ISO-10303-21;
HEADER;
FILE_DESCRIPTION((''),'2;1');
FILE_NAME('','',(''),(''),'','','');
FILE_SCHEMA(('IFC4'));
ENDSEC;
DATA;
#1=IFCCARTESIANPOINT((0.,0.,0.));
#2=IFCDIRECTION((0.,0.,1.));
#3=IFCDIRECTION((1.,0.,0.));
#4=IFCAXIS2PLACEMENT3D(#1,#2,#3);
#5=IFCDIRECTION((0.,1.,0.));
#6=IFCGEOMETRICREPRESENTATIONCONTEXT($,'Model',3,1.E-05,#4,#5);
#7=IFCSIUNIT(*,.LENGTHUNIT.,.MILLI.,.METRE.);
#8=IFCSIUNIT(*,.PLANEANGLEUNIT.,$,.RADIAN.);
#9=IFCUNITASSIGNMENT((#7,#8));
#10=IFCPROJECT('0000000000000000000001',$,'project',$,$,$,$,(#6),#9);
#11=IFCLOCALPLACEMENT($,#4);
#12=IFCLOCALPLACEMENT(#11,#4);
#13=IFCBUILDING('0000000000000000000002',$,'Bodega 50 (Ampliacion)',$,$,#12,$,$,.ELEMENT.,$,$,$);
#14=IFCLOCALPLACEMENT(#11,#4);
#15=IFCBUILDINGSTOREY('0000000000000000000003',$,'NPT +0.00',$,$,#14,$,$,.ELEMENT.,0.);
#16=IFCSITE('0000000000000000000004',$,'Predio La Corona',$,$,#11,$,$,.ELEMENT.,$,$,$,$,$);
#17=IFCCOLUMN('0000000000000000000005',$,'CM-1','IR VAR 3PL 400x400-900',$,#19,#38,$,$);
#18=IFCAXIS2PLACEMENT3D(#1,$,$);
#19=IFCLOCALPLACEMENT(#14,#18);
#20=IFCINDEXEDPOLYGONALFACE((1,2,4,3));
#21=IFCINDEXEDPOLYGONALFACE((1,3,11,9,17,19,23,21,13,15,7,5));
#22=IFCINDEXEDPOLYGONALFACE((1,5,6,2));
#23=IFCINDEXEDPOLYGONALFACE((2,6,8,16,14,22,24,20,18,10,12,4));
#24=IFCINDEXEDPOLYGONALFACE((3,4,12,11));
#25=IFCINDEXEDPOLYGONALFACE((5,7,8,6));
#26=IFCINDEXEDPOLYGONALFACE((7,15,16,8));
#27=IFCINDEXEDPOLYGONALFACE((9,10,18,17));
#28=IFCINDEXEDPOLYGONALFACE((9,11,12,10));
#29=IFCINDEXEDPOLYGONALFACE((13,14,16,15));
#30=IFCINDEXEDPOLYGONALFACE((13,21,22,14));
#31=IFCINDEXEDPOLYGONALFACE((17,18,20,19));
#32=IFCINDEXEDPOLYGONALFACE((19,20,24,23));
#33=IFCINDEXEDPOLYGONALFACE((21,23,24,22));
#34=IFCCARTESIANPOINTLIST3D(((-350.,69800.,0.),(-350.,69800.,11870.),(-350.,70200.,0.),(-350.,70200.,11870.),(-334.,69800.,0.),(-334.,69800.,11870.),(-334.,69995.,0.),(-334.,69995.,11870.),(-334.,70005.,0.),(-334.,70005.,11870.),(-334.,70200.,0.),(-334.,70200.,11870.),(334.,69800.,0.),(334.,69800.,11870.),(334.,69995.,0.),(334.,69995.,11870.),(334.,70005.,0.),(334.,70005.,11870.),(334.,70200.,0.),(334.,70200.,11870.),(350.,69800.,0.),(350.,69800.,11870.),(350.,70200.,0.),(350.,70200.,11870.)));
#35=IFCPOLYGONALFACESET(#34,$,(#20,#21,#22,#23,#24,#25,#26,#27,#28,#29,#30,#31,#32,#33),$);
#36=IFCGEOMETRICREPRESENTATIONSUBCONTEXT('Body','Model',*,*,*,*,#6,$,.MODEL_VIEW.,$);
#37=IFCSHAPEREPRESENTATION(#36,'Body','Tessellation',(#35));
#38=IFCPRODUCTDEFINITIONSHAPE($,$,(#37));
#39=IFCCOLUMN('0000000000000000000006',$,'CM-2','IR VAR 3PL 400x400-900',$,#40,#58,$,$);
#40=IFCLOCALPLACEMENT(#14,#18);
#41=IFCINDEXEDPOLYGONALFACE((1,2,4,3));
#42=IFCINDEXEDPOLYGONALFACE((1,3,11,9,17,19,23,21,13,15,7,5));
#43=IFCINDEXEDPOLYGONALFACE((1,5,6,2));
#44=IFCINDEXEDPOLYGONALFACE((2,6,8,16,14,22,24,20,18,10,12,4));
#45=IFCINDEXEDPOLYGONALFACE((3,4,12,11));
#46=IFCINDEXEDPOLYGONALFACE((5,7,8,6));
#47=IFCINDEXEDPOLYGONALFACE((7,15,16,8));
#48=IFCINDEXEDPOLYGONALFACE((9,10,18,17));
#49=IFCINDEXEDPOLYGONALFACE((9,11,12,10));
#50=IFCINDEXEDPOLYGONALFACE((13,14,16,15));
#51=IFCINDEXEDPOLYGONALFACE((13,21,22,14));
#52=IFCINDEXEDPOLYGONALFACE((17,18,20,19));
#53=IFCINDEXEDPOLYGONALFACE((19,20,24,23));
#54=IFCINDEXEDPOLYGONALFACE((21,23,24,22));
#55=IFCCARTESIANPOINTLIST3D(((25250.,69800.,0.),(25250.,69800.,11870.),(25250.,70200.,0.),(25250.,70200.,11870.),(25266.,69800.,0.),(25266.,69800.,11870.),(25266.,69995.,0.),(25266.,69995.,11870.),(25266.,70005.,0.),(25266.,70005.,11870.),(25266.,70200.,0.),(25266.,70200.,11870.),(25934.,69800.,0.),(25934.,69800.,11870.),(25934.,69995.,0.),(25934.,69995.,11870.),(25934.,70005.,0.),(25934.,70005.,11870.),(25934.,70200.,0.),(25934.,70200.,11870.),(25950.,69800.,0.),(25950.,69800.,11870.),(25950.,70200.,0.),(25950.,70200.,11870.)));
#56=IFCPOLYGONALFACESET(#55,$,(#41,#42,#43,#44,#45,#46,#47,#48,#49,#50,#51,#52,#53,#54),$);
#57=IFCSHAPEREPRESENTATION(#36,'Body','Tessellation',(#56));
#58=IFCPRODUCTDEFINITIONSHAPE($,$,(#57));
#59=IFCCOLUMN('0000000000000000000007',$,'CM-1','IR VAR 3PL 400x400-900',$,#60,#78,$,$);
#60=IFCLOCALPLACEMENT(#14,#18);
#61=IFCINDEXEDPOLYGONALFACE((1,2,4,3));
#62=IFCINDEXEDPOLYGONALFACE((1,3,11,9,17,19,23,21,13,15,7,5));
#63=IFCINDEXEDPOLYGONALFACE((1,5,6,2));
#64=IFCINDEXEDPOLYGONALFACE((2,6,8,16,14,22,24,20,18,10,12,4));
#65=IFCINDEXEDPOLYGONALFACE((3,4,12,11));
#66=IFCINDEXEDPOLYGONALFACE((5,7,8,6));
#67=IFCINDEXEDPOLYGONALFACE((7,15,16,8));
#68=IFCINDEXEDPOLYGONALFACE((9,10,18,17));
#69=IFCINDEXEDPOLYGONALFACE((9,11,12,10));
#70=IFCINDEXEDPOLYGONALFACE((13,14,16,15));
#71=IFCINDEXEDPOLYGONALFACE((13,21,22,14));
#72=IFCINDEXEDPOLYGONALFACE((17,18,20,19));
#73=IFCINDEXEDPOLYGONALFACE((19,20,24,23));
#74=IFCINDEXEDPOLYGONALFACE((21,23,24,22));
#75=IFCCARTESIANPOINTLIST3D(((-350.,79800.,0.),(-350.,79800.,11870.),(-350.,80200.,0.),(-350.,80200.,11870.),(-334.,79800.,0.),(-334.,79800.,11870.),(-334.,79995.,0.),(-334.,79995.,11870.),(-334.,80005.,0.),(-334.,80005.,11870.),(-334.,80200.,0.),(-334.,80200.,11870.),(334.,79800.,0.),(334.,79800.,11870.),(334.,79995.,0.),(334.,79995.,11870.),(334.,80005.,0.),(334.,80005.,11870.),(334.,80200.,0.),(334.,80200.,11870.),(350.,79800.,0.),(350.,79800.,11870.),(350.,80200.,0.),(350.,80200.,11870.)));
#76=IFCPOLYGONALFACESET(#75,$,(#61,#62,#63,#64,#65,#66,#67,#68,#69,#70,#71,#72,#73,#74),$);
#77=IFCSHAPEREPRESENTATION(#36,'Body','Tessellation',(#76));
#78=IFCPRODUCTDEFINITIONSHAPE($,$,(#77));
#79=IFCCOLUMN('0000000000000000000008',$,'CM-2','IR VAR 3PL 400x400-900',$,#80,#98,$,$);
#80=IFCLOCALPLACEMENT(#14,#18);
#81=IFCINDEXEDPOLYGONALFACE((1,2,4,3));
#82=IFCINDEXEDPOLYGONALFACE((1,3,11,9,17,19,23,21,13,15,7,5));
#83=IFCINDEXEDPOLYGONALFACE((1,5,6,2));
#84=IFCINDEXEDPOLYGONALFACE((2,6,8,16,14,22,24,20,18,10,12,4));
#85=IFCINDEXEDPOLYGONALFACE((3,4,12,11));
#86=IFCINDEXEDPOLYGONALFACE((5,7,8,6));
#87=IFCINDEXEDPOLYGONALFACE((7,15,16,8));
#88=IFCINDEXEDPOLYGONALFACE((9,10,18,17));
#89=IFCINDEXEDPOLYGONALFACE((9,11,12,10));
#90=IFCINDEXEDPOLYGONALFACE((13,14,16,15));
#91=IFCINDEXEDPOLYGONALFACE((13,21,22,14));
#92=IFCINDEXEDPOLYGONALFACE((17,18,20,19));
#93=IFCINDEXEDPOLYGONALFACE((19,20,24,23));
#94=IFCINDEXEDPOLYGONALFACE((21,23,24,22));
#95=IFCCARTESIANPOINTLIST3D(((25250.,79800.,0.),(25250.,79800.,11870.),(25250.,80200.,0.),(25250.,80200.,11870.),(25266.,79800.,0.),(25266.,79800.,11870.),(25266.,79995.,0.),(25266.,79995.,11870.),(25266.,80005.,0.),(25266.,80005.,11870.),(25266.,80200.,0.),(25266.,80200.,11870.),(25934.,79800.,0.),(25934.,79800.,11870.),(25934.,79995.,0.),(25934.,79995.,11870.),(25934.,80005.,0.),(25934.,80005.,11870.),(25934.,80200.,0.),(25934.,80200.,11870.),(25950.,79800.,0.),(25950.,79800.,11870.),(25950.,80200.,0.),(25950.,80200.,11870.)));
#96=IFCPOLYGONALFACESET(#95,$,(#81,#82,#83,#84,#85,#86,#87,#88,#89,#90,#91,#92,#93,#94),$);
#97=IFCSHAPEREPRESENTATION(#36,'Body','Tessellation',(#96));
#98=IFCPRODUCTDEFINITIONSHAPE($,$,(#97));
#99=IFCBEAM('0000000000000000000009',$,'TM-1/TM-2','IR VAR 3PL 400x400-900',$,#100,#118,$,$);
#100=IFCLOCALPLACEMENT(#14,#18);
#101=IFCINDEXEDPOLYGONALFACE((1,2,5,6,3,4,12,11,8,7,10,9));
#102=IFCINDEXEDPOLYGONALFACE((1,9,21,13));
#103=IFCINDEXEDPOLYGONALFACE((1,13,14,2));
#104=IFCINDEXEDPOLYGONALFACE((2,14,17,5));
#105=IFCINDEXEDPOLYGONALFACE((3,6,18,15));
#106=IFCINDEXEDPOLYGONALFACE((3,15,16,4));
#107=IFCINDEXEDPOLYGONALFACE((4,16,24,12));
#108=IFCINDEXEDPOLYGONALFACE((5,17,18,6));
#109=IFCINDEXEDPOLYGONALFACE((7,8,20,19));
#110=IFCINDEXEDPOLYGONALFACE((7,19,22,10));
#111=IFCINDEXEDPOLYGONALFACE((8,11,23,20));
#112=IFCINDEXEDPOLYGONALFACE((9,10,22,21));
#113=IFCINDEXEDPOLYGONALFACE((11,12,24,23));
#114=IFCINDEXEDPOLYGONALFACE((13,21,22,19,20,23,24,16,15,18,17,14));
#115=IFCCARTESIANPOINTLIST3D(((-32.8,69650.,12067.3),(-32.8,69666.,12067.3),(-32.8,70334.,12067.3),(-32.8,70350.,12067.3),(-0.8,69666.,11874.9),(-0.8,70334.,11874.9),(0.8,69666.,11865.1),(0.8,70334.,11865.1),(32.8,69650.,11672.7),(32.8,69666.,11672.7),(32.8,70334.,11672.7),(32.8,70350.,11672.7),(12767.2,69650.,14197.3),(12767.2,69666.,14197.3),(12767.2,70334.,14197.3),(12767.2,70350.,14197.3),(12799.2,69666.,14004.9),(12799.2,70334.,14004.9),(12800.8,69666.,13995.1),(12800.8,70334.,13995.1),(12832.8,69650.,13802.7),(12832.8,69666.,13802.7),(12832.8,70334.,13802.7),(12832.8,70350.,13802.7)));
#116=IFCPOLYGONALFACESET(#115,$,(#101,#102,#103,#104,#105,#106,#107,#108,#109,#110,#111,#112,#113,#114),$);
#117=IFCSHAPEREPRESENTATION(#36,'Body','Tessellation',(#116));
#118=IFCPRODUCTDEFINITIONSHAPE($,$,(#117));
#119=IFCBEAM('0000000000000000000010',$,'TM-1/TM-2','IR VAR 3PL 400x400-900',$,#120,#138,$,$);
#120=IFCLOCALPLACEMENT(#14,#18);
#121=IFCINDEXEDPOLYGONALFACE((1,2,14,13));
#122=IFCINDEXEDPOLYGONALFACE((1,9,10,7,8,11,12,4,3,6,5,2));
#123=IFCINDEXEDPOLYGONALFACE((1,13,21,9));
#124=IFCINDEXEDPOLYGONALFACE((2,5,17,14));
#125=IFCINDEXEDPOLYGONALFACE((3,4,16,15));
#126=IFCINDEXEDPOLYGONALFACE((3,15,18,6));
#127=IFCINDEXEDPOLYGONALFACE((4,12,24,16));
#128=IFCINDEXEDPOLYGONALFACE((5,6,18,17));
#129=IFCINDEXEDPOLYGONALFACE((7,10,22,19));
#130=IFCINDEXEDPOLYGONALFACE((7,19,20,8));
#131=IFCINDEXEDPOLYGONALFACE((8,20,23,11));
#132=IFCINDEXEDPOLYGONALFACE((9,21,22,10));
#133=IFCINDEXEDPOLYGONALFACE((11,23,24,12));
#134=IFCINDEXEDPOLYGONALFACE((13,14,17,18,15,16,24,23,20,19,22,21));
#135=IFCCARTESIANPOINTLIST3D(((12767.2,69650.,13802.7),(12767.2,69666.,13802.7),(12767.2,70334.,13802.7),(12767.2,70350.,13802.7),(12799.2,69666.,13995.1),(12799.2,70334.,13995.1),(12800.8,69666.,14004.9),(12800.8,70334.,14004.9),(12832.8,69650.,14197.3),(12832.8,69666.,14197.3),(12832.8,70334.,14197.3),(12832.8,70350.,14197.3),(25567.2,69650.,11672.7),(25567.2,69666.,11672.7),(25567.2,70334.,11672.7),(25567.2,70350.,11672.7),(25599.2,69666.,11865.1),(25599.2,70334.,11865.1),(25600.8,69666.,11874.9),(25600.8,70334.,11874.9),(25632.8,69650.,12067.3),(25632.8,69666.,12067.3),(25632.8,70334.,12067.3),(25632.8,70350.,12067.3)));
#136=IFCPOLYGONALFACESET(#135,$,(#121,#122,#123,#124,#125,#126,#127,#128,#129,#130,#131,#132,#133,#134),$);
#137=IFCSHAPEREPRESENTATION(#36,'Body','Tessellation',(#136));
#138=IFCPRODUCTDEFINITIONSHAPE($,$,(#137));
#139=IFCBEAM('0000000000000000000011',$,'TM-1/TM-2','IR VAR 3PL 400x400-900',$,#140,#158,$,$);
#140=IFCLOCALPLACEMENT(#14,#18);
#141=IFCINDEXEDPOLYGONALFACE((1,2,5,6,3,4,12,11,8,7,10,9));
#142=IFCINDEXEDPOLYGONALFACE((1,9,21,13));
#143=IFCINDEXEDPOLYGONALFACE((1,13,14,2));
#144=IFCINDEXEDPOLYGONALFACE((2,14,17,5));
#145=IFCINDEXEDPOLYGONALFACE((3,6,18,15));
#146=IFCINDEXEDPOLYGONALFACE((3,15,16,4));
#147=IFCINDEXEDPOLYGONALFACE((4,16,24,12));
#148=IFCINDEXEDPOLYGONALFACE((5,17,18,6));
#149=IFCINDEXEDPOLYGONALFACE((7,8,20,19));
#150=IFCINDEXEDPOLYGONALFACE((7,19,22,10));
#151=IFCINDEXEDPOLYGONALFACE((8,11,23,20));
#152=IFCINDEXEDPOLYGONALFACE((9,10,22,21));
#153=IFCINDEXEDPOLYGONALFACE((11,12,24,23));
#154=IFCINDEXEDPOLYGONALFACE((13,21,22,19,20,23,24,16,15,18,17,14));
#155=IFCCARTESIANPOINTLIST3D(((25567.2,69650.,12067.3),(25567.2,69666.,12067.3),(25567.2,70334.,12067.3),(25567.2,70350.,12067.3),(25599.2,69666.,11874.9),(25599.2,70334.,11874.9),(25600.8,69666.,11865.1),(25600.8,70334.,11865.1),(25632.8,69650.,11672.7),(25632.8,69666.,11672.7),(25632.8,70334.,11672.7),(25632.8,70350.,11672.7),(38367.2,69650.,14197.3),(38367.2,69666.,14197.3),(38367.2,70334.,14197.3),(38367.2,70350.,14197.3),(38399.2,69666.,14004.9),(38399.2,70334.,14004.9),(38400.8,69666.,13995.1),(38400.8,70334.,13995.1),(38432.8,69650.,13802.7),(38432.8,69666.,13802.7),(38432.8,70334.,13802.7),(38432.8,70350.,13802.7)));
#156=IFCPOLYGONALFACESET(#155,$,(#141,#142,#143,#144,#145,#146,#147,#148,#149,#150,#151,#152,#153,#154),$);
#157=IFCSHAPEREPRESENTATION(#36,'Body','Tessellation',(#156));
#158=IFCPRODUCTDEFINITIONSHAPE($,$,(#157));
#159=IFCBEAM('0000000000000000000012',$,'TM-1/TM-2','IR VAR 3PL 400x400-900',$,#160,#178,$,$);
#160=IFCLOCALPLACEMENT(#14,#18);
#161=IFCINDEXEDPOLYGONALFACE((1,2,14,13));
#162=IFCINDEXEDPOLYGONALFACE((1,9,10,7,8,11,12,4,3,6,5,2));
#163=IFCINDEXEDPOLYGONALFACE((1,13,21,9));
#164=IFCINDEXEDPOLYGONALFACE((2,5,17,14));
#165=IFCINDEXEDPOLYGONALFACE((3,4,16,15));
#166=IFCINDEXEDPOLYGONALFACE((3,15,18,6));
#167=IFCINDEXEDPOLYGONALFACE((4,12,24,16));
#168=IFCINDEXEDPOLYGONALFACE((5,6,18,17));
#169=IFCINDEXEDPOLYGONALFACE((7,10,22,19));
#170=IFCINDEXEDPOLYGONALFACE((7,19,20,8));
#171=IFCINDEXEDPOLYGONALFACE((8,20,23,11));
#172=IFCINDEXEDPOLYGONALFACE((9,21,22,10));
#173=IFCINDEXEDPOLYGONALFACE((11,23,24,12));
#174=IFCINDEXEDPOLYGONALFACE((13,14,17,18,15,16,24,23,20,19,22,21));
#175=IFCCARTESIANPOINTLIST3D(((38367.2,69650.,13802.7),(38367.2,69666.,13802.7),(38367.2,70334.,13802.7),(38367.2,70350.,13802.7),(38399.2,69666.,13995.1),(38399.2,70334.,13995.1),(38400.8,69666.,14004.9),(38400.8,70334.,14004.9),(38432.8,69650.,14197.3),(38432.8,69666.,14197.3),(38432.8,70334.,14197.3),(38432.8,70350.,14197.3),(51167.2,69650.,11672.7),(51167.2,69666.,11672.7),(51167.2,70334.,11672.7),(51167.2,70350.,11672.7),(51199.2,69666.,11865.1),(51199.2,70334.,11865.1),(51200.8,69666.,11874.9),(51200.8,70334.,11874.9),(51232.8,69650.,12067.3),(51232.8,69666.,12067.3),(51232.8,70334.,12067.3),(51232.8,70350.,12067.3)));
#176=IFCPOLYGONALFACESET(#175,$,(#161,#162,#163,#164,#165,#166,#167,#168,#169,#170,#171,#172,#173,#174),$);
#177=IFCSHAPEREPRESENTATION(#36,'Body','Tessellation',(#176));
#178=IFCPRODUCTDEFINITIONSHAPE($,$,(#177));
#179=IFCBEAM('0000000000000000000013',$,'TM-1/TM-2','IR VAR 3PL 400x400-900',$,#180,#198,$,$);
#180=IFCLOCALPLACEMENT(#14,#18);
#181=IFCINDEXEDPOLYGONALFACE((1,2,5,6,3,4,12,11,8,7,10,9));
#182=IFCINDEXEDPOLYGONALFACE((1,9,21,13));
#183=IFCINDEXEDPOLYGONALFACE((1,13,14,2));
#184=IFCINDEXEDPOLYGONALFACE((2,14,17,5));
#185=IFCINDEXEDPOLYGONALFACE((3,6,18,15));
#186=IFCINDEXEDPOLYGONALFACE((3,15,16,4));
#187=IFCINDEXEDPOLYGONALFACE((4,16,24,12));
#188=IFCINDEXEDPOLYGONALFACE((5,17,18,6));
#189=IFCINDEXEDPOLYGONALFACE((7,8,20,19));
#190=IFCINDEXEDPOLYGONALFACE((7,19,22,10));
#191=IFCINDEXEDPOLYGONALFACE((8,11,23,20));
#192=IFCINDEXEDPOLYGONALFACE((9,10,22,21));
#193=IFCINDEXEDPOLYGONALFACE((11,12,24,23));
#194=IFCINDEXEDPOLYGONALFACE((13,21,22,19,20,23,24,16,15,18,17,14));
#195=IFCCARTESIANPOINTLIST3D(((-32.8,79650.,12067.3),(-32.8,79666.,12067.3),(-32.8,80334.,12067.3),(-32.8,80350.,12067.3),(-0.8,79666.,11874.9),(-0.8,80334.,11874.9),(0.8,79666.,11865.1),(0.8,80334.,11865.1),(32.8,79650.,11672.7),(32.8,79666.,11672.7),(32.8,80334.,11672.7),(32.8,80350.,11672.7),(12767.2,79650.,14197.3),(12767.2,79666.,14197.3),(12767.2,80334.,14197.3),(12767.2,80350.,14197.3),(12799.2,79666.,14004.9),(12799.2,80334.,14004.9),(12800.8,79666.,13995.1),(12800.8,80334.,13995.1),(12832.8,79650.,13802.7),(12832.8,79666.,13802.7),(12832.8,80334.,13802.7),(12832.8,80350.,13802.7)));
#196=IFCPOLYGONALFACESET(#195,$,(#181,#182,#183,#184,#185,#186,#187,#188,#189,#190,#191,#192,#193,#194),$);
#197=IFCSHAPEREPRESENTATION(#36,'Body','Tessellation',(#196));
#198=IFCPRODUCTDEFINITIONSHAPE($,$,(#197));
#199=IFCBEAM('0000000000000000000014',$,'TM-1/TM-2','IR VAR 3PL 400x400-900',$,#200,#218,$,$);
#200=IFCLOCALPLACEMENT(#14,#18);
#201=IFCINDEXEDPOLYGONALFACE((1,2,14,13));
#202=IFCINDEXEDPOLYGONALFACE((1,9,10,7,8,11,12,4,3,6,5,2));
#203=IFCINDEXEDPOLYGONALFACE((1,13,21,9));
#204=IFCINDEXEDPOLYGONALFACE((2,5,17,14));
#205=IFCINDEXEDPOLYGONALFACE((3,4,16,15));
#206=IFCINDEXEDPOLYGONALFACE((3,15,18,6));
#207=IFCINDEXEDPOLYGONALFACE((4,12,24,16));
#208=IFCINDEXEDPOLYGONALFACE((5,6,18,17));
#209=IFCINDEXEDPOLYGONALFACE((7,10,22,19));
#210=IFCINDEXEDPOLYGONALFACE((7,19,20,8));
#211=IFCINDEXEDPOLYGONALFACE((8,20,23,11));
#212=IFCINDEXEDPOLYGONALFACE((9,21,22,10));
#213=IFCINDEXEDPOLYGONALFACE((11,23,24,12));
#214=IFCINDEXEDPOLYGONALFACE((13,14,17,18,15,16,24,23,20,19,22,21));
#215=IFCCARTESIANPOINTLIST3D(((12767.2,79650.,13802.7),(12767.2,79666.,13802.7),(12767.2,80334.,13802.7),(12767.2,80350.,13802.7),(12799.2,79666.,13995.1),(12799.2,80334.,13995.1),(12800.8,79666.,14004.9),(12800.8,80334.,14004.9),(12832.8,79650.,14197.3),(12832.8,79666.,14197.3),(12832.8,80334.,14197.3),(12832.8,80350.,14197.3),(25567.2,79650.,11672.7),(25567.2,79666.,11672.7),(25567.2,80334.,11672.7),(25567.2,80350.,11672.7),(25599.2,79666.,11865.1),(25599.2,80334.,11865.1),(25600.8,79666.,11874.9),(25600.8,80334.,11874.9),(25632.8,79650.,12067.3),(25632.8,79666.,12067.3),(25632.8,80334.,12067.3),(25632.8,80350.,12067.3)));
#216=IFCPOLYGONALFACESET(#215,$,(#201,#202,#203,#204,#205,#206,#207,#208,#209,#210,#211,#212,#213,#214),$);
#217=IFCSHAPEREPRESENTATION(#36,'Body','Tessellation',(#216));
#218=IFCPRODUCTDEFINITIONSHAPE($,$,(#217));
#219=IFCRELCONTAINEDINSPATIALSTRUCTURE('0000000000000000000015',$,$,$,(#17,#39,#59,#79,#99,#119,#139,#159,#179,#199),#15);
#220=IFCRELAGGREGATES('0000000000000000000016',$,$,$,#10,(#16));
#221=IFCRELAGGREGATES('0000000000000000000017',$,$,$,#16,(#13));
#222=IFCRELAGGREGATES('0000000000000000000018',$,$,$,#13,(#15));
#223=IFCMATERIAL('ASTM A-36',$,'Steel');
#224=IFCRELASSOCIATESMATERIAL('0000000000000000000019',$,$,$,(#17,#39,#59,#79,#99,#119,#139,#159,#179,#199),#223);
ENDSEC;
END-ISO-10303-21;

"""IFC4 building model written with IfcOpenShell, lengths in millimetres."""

from ifc_helpers import new_model, si_unit, direction, frame, origin_with_axes, origin_2d, place, context, subcontext, project, spatial, i_section, extrude, material, element, save


model = new_model("IFC4")

# Units and contexts
model_context = context("Model", 3, precision=1e-05, world=origin_with_axes(), true_north=direction((0.0, 1.0, 0.0)))
body_context = subcontext(model_context, "Body", "Model", "MODEL_VIEW")
ifc_project = project(units=[si_unit("LENGTHUNIT", "METRE", prefix="MILLI"), si_unit("PLANEANGLEUNIT", "RADIAN")], contexts=[model_context])

# Site, building, storey
site_placement = place(None, origin_with_axes())
site = spatial("IfcSite", under=ifc_project, at=site_placement, Name="Predio La Corona", CompositionType="ELEMENT")
building_placement = place(site_placement, origin_with_axes())
building = spatial("IfcBuilding", under=site, at=building_placement, Name="Bodega 50 (Ampliacion)", CompositionType="ELEMENT")
storey_placement = place(site_placement, origin_with_axes())
storey = spatial("IfcBuildingStorey", under=building, at=storey_placement, Name="NPT +0.00", CompositionType="ELEMENT", Elevation=0.0)

# Columns
ifc_material = material(Name="ASTM A-36", Category="Steel")
for number, where, z_axis, x_axis, name in (
    (1, (0.0, 70000.0, 0.0), (0.0, 0.0, 1.0), (0.0, -1.0, 0.0), "CM-1"),
    (2, (25600.0, 70000.0, 0.0), (0.0, 0.0, 1.0), (0.0, -1.0, 0.0), "CM-2"),
    (3, (0.0, 80000.0, 0.0), (0.0, 0.0, 1.0), (0.0, -1.0, 0.0), "CM-1"),
    (4, (25600.0, 80000.0, 0.0), (0.0, 0.0, 1.0), (0.0, -1.0, 0.0), "CM-2"),
):
    element("IfcColumn", number, at=place(storey_placement, frame(where, z_axis=z_axis, x_axis=x_axis)), inside=storey, material=ifc_material, Name=name, Description="IR VAR 3PL 400x400-900", context=body_context, shape_type="SweptSolid", body=[
        extrude(i_section(OverallWidth=400.0, OverallDepth=700.0, WebThickness=10.0, FlangeThickness=16.0, at=origin_2d()), origin_with_axes(), (0.0, 0.0, 1.0), 11870.0),
    ])

# Beams
for number, where, z_axis, x_axis, name in (
    (5, (0.0, 70000.0, 11870.0), (0.986436, 0.0, 0.164149), (0.164149, 0.0, -0.986436), "TM-1/TM-2"),
    (6, (12800.0, 70000.0, 14000.0), (0.986436, 0.0, -0.164149), (-0.164149, 0.0, -0.986436), "TM-1/TM-2"),
    (7, (25600.0, 70000.0, 11870.0), (0.986436, 0.0, 0.164149), (0.164149, 0.0, -0.986436), "TM-1/TM-2"),
    (8, (38400.0, 70000.0, 14000.0), (0.986436, 0.0, -0.164149), (-0.164149, 0.0, -0.986436), "TM-1/TM-2"),
    (9, (0.0, 80000.0, 11870.0), (0.986436, 0.0, 0.164149), (0.164149, 0.0, -0.986436), "TM-1/TM-2"),
    (10, (12800.0, 80000.0, 14000.0), (0.986436, 0.0, -0.164149), (-0.164149, 0.0, -0.986436), "TM-1/TM-2"),
):
    element("IfcBeam", number, at=place(storey_placement, frame(where, z_axis=z_axis, x_axis=x_axis)), inside=storey, material=ifc_material, Name=name, Description="IR VAR 3PL 400x400-900", context=body_context, shape_type="SweptSolid", body=[
        extrude(i_section(OverallWidth=400.0, OverallDepth=700.0, WebThickness=10.0, FlangeThickness=16.0, at=origin_2d()), origin_with_axes(), (0.0, 0.0, 1.0), 12976.0),
    ])

save(model, "model.ifc")
